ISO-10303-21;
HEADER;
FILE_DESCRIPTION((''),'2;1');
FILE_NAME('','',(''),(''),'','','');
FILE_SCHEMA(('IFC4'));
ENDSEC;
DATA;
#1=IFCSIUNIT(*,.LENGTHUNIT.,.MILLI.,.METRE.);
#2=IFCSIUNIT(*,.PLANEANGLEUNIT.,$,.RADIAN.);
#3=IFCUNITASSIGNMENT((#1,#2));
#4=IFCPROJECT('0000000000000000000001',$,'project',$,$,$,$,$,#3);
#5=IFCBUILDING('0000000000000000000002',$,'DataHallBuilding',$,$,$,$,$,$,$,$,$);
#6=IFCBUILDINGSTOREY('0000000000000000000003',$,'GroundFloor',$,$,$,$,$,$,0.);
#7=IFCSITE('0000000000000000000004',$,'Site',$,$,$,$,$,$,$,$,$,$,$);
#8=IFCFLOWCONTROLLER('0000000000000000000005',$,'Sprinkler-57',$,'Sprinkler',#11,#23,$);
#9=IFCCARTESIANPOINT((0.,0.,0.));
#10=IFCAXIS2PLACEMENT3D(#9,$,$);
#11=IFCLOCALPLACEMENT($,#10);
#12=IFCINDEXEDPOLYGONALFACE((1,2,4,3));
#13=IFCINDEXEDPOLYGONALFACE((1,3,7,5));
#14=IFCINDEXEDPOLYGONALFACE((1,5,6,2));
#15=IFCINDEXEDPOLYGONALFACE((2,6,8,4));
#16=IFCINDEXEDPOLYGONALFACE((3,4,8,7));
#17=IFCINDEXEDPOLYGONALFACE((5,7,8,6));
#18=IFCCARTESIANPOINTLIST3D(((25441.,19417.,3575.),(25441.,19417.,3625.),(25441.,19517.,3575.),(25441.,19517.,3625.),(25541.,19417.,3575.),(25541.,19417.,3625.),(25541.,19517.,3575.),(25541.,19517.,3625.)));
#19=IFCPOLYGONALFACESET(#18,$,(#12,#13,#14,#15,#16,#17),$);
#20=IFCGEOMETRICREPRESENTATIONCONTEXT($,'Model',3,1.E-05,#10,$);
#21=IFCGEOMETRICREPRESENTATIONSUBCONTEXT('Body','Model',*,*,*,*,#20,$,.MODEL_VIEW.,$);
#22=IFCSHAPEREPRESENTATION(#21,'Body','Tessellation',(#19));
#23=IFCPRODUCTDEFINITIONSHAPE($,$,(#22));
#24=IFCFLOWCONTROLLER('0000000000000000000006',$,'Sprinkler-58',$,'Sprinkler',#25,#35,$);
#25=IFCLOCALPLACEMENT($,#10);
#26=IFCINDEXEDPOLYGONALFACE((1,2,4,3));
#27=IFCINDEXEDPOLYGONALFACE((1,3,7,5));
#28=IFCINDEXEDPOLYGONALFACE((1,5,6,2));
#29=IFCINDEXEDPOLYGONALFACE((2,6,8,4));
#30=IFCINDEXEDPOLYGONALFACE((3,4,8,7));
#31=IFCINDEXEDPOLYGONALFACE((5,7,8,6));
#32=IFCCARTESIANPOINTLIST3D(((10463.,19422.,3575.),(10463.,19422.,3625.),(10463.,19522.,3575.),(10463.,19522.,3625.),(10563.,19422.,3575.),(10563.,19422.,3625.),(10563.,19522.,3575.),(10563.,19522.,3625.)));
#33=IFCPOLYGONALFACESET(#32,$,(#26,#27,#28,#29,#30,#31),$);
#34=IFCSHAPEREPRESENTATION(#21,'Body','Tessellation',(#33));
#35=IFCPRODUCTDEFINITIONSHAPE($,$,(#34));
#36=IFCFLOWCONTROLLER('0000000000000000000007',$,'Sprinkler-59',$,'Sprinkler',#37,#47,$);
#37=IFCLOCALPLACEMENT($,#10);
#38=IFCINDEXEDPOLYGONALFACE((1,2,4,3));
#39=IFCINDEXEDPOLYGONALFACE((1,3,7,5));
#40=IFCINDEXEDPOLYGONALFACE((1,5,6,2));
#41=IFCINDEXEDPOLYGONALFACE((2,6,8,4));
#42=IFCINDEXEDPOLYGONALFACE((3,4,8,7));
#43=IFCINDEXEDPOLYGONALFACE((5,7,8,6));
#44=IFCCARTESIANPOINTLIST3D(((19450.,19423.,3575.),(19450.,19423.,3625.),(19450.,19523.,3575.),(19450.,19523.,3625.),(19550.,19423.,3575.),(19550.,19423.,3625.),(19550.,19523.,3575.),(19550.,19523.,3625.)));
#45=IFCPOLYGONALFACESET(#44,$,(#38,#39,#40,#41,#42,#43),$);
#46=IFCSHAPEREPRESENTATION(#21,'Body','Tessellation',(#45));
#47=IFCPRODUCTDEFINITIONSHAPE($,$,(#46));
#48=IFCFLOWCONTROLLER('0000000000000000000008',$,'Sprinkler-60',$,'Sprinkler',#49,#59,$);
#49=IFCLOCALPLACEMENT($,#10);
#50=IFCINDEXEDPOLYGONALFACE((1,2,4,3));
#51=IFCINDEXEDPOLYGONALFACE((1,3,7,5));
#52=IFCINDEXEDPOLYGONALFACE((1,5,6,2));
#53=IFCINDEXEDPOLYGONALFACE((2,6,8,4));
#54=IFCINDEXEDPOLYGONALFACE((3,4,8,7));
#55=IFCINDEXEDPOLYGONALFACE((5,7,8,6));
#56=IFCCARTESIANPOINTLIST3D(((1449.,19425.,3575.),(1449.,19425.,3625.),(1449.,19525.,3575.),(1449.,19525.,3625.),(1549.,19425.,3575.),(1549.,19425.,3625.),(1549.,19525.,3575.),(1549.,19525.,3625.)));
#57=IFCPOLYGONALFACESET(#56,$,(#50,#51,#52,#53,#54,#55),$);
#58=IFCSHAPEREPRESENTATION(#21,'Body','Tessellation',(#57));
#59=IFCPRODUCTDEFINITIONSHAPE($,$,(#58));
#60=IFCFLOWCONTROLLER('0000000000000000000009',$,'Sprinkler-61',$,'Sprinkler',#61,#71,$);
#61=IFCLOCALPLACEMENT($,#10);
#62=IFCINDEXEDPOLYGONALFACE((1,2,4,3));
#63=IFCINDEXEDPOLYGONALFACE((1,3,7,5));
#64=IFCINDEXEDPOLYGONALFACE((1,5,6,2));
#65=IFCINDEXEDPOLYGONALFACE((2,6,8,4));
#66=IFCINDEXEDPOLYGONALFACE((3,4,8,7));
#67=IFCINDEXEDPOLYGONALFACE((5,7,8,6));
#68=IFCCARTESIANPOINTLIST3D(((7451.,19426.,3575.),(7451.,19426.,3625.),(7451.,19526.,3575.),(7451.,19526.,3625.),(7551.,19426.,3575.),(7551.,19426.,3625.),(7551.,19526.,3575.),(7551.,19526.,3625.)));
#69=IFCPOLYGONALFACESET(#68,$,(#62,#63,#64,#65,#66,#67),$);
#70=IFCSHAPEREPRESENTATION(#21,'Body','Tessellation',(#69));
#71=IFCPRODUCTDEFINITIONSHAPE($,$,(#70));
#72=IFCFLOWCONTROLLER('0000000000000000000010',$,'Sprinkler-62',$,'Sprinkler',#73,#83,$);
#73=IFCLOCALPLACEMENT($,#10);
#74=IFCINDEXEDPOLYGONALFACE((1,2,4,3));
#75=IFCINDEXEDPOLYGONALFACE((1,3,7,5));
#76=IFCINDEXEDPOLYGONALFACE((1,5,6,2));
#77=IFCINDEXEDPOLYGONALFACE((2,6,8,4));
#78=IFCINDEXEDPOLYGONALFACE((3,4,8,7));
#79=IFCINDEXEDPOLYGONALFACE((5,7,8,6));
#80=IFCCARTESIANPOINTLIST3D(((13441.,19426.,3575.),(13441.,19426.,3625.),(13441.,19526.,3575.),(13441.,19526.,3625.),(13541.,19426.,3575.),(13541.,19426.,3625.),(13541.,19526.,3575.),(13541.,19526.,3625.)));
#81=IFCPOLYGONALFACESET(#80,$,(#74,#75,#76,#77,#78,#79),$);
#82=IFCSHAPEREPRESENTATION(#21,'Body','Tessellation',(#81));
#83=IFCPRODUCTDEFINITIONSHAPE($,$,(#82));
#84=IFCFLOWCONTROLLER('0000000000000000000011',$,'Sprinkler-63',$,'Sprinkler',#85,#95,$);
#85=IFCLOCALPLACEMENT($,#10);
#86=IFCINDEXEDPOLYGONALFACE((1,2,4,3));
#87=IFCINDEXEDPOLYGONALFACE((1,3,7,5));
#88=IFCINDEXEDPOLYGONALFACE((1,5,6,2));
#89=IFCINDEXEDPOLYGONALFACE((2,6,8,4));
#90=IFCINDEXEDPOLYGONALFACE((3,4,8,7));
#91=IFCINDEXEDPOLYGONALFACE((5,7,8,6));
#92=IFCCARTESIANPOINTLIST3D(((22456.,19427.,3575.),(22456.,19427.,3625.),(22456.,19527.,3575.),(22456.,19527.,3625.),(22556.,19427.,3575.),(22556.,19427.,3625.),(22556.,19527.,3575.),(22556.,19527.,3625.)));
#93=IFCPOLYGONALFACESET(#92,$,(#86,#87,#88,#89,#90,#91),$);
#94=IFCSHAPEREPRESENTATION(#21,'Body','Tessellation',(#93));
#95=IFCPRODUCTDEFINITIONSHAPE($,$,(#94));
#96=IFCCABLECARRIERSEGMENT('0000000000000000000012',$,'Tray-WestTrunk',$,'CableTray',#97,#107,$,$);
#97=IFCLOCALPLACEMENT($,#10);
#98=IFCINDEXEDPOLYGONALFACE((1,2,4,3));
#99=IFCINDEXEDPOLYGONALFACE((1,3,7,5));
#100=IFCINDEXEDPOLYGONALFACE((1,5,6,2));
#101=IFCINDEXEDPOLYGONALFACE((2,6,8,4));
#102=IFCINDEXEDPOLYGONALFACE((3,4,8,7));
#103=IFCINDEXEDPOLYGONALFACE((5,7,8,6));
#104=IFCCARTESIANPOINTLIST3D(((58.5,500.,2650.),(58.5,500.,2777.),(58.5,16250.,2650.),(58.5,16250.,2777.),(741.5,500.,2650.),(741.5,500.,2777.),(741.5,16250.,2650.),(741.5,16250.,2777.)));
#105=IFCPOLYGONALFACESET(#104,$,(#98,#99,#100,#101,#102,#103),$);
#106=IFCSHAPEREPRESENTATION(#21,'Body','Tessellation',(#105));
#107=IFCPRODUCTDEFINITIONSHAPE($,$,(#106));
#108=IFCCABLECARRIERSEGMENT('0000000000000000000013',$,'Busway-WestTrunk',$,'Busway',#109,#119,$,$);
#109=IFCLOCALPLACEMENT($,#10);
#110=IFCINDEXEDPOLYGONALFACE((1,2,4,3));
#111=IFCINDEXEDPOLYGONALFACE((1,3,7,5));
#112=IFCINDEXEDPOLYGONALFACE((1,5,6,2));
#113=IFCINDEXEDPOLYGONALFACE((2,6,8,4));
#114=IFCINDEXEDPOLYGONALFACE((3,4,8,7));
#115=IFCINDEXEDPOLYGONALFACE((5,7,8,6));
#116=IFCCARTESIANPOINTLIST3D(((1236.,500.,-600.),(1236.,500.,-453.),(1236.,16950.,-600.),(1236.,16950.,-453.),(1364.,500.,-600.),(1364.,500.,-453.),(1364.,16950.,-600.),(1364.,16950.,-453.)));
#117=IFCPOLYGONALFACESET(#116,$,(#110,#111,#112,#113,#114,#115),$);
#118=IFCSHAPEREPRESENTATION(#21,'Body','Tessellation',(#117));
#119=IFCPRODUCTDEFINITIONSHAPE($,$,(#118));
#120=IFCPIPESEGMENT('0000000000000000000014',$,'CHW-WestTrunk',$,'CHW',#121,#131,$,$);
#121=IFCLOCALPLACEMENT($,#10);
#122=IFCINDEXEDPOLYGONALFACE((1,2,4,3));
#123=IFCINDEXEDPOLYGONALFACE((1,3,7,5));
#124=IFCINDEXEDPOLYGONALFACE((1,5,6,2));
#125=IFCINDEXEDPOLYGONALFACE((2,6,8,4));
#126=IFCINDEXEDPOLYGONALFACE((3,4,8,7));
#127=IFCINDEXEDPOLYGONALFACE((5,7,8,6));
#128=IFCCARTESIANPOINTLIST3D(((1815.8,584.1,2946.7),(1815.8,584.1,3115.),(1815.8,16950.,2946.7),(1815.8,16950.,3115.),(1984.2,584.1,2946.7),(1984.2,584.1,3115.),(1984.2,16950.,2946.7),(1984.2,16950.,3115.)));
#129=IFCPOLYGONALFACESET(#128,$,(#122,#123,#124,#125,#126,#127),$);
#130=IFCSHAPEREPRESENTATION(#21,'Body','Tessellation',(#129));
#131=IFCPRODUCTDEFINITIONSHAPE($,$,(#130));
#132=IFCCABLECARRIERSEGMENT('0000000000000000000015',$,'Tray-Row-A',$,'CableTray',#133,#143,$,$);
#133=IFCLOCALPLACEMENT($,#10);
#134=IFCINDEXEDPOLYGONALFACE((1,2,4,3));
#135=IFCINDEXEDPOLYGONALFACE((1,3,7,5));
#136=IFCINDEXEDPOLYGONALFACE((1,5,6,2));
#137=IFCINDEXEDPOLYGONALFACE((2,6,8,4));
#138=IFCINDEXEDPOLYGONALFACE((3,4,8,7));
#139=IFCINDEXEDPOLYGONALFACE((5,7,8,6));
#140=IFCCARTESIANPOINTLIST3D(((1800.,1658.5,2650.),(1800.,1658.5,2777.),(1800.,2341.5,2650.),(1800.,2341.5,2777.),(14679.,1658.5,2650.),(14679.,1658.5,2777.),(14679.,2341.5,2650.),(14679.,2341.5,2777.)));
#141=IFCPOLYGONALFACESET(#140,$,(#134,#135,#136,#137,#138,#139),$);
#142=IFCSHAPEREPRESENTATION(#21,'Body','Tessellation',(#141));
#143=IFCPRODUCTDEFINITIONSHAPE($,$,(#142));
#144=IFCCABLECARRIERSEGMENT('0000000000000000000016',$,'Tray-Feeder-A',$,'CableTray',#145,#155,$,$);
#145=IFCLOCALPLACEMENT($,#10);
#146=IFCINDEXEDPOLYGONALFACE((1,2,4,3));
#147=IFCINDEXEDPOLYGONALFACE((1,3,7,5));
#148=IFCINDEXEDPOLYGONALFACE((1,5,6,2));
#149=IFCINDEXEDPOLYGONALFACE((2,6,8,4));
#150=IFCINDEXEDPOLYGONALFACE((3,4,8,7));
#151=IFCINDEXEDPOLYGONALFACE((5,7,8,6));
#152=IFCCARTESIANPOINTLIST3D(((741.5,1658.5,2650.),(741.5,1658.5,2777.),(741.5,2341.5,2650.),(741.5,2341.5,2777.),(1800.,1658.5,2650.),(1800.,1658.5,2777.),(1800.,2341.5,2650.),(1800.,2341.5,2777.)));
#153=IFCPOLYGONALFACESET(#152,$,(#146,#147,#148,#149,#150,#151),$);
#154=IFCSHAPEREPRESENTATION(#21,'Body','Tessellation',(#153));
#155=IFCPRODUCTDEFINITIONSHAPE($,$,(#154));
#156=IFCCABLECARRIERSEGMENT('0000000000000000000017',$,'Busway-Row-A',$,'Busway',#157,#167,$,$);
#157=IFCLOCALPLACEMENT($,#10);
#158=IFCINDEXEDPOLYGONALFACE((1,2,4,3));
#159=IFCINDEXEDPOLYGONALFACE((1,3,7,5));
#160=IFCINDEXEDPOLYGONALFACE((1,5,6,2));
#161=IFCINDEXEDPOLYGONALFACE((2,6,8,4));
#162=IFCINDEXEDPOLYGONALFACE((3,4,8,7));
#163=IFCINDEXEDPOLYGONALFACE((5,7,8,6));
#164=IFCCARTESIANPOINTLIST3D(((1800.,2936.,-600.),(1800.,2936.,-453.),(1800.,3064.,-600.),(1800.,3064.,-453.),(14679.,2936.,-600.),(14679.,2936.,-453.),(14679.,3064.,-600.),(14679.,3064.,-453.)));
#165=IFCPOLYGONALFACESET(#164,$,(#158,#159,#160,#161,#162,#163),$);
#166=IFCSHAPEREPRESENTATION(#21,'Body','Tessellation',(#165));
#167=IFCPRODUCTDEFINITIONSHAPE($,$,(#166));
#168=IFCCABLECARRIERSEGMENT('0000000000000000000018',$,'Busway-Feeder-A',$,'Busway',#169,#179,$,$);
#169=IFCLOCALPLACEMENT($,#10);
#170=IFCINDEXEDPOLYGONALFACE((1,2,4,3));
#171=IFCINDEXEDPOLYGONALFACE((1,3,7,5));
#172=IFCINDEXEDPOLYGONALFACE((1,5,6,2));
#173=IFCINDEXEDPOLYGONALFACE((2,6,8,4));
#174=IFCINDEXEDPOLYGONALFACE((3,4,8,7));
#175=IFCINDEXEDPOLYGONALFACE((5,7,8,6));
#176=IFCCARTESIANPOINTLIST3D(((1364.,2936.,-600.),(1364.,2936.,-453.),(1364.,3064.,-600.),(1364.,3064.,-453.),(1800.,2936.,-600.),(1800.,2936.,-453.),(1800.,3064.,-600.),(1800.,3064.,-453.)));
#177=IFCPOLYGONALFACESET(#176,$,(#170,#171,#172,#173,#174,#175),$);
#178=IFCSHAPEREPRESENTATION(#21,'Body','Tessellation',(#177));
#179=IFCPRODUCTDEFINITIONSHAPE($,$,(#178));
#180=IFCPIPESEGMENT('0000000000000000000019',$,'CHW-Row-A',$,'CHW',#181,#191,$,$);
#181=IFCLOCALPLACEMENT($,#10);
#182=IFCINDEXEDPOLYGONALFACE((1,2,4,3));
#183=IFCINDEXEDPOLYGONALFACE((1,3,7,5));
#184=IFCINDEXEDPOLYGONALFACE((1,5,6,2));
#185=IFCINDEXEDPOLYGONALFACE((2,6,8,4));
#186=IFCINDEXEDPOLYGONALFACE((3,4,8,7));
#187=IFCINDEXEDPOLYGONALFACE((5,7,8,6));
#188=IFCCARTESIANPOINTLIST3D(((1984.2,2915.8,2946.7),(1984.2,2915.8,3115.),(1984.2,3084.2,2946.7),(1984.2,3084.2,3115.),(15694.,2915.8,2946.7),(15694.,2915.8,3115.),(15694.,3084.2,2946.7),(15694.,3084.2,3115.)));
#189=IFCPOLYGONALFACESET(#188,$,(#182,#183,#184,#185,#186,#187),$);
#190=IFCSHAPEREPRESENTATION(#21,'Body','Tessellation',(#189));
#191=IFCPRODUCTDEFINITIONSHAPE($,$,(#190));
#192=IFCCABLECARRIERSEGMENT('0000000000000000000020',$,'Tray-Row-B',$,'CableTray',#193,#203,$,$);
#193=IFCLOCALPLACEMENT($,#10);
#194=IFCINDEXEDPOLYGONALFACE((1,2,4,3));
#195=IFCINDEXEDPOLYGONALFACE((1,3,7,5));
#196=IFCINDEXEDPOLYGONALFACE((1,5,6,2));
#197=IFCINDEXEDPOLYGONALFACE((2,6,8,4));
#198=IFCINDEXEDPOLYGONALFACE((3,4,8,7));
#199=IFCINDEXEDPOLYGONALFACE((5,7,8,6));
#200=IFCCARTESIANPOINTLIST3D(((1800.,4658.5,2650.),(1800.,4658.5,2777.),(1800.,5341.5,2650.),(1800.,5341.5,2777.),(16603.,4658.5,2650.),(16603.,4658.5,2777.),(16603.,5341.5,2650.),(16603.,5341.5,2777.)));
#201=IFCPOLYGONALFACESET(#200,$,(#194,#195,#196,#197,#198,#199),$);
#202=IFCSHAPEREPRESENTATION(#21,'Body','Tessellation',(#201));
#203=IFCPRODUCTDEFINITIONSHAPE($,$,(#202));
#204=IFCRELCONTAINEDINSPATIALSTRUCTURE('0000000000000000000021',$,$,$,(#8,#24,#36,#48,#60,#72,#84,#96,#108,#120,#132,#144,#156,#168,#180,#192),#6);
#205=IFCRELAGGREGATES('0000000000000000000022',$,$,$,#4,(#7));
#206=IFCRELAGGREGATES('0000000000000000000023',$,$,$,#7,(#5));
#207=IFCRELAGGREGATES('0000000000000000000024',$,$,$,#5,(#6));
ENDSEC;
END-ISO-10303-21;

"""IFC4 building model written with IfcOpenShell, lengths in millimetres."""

from ifc_helpers import new_model, si_unit, frame, origin, place, context, subcontext, project, spatial, rectangle, extrude, element, save


model = new_model("IFC4")

# Units and contexts
model_context = context("Model", 3, precision=1e-05, world=origin())
body_context = subcontext(model_context, "Body", "Model", "MODEL_VIEW")
ifc_project = project(units=[si_unit("LENGTHUNIT", "METRE", prefix="MILLI"), si_unit("PLANEANGLEUNIT", "RADIAN")])

# Site, building, storey
site = spatial("IfcSite", under=ifc_project, Name="Site")
building = spatial("IfcBuilding", under=site, Name="DataHallBuilding")
storey = spatial("IfcBuildingStorey", under=building, Name="GroundFloor", Elevation=0.0)

# Flow controllers
flow_controller_1_placement = place(None, origin())
element("IfcFlowController", 1, at=flow_controller_1_placement, inside=storey, Name="Sprinkler-57", ObjectType="Sprinkler", context=body_context, shape_type="SweptSolid", body=[
    extrude(rectangle(XDim=100.0, YDim=100.0), frame((25491.0, 19467.0, 3575.0), z_axis=(0.0, 0.0, 1.0), x_axis=(1.0, 0.0, 0.0)), (0.0, 0.0, 1.0), 50.0),
])
flow_controller_2_placement = place(None, origin())
element("IfcFlowController", 2, at=flow_controller_2_placement, inside=storey, Name="Sprinkler-58", ObjectType="Sprinkler", context=body_context, shape_type="SweptSolid", body=[
    extrude(rectangle(XDim=100.0, YDim=100.0), frame((10513.0, 19472.0, 3575.0), z_axis=(0.0, 0.0, 1.0), x_axis=(1.0, 0.0, 0.0)), (0.0, 0.0, 1.0), 50.0),
])
flow_controller_3_placement = place(None, origin())
element("IfcFlowController", 3, at=flow_controller_3_placement, inside=storey, Name="Sprinkler-59", ObjectType="Sprinkler", context=body_context, shape_type="SweptSolid", body=[
    extrude(rectangle(XDim=100.0, YDim=100.0), frame((19500.0, 19473.0, 3575.0), z_axis=(0.0, 0.0, 1.0), x_axis=(1.0, 0.0, 0.0)), (0.0, 0.0, 1.0), 50.0),
])
flow_controller_4_placement = place(None, origin())
element("IfcFlowController", 4, at=flow_controller_4_placement, inside=storey, Name="Sprinkler-60", ObjectType="Sprinkler", context=body_context, shape_type="SweptSolid", body=[
    extrude(rectangle(XDim=100.0, YDim=100.0), frame((1499.0, 19475.0, 3575.0), z_axis=(0.0, 0.0, 1.0), x_axis=(1.0, 0.0, 0.0)), (0.0, 0.0, 1.0), 50.0),
])
flow_controller_5_placement = place(None, origin())
element("IfcFlowController", 5, at=flow_controller_5_placement, inside=storey, Name="Sprinkler-61", ObjectType="Sprinkler", context=body_context, shape_type="SweptSolid", body=[
    extrude(rectangle(XDim=100.0, YDim=100.0), frame((7501.0, 19476.0, 3575.0), z_axis=(0.0, 0.0, 1.0), x_axis=(1.0, 0.0, 0.0)), (0.0, 0.0, 1.0), 50.0),
])
flow_controller_6_placement = place(None, origin())
element("IfcFlowController", 6, at=flow_controller_6_placement, inside=storey, Name="Sprinkler-62", ObjectType="Sprinkler", context=body_context, shape_type="SweptSolid", body=[
    extrude(rectangle(XDim=100.0, YDim=100.0), frame((13491.0, 19476.0, 3575.0), z_axis=(0.0, 0.0, 1.0), x_axis=(1.0, 0.0, 0.0)), (0.0, 0.0, 1.0), 50.0),
])
flow_controller_7_placement = place(None, origin())
element("IfcFlowController", 7, at=flow_controller_7_placement, inside=storey, Name="Sprinkler-63", ObjectType="Sprinkler", context=body_context, shape_type="SweptSolid", body=[
    extrude(rectangle(XDim=100.0, YDim=100.0), frame((22506.0, 19477.0, 3575.0), z_axis=(0.0, 0.0, 1.0), x_axis=(1.0, 0.0, 0.0)), (0.0, 0.0, 1.0), 50.0),
])

# Cable carrier segments
cable_carrier_segment_1_placement = place(None, origin())
element("IfcCableCarrierSegment", 8, at=cable_carrier_segment_1_placement, inside=storey, Name="Tray-WestTrunk", ObjectType="CableTray", context=body_context, shape_type="SweptSolid", body=[
    extrude(rectangle(XDim=683.0, YDim=15750.0), frame((400.0, 8375.0, 2650.0), z_axis=(0.0, 0.0, 1.0), x_axis=(1.0, 0.0, 0.0)), (0.0, 0.0, 1.0), 127.0),
])
cable_carrier_segment_2_placement = place(None, origin())
element("IfcCableCarrierSegment", 9, at=cable_carrier_segment_2_placement, inside=storey, Name="Busway-WestTrunk", ObjectType="Busway", context=body_context, shape_type="SweptSolid", body=[
    extrude(rectangle(XDim=128.0, YDim=16450.0), frame((1300.0, 8725.0, -600.0), z_axis=(0.0, 0.0, 1.0), x_axis=(1.0, 0.0, 0.0)), (0.0, 0.0, 1.0), 147.0),
])

# Pipe segment
pipe_segment_1_placement = place(None, origin())
element("IfcPipeSegment", 10, at=pipe_segment_1_placement, inside=storey, Name="CHW-WestTrunk", ObjectType="CHW", context=body_context, shape_type="SweptSolid", body=[
    extrude(rectangle(XDim=168.3, YDim=16365.9), frame((1900.0, 8767.1, 2946.7), z_axis=(0.0, 0.0, 1.0), x_axis=(1.0, 0.0, 0.0)), (0.0, 0.0, 1.0), 168.3),
])

# Cable carrier segments
cable_carrier_segment_3_placement = place(None, origin())
element("IfcCableCarrierSegment", 11, at=cable_carrier_segment_3_placement, inside=storey, Name="Tray-Row-A", ObjectType="CableTray", context=body_context, shape_type="SweptSolid", body=[
    extrude(rectangle(XDim=12879.0, YDim=683.0), frame((8239.5, 2000.0, 2650.0), z_axis=(0.0, 0.0, 1.0), x_axis=(1.0, 0.0, 0.0)), (0.0, 0.0, 1.0), 127.0),
])
cable_carrier_segment_4_placement = place(None, origin())
element("IfcCableCarrierSegment", 12, at=cable_carrier_segment_4_placement, inside=storey, Name="Tray-Feeder-A", ObjectType="CableTray", context=body_context, shape_type="SweptSolid", body=[
    extrude(rectangle(XDim=1058.5, YDim=683.0), frame((1270.8, 2000.0, 2650.0), z_axis=(0.0, 0.0, 1.0), x_axis=(1.0, 0.0, 0.0)), (0.0, 0.0, 1.0), 127.0),
])
cable_carrier_segment_5_placement = place(None, origin())
element("IfcCableCarrierSegment", 13, at=cable_carrier_segment_5_placement, inside=storey, Name="Busway-Row-A", ObjectType="Busway", context=body_context, shape_type="SweptSolid", body=[
    extrude(rectangle(XDim=12879.0, YDim=128.0), frame((8239.5, 3000.0, -600.0), z_axis=(0.0, 0.0, 1.0), x_axis=(1.0, 0.0, 0.0)), (0.0, 0.0, 1.0), 147.0),
])
cable_carrier_segment_6_placement = place(None, origin())
element("IfcCableCarrierSegment", 14, at=cable_carrier_segment_6_placement, inside=storey, Name="Busway-Feeder-A", ObjectType="Busway", context=body_context, shape_type="SweptSolid", body=[
    extrude(rectangle(XDim=436.0, YDim=128.0), frame((1582.0, 3000.0, -600.0), z_axis=(0.0, 0.0, 1.0), x_axis=(1.0, 0.0, 0.0)), (0.0, 0.0, 1.0), 147.0),
])

# Pipe segment
pipe_segment_2_placement = place(None, origin())
element("IfcPipeSegment", 15, at=pipe_segment_2_placement, inside=storey, Name="CHW-Row-A", ObjectType="CHW", context=body_context, shape_type="SweptSolid", body=[
    extrude(rectangle(XDim=13709.9, YDim=168.3), frame((8839.1, 3000.0, 2946.7), z_axis=(0.0, 0.0, 1.0), x_axis=(1.0, 0.0, 0.0)), (0.0, 0.0, 1.0), 168.3),
])

# Cable carrier segment
cable_carrier_segment_7_placement = place(None, origin())
element("IfcCableCarrierSegment", 16, at=cable_carrier_segment_7_placement, inside=storey, Name="Tray-Row-B", ObjectType="CableTray", context=body_context, shape_type="SweptSolid", body=[
    extrude(rectangle(XDim=14803.0, YDim=683.0), frame((9201.5, 5000.0, 2650.0), z_axis=(0.0, 0.0, 1.0), x_axis=(1.0, 0.0, 0.0)), (0.0, 0.0, 1.0), 127.0),
])

save(model, "model.ifc")
